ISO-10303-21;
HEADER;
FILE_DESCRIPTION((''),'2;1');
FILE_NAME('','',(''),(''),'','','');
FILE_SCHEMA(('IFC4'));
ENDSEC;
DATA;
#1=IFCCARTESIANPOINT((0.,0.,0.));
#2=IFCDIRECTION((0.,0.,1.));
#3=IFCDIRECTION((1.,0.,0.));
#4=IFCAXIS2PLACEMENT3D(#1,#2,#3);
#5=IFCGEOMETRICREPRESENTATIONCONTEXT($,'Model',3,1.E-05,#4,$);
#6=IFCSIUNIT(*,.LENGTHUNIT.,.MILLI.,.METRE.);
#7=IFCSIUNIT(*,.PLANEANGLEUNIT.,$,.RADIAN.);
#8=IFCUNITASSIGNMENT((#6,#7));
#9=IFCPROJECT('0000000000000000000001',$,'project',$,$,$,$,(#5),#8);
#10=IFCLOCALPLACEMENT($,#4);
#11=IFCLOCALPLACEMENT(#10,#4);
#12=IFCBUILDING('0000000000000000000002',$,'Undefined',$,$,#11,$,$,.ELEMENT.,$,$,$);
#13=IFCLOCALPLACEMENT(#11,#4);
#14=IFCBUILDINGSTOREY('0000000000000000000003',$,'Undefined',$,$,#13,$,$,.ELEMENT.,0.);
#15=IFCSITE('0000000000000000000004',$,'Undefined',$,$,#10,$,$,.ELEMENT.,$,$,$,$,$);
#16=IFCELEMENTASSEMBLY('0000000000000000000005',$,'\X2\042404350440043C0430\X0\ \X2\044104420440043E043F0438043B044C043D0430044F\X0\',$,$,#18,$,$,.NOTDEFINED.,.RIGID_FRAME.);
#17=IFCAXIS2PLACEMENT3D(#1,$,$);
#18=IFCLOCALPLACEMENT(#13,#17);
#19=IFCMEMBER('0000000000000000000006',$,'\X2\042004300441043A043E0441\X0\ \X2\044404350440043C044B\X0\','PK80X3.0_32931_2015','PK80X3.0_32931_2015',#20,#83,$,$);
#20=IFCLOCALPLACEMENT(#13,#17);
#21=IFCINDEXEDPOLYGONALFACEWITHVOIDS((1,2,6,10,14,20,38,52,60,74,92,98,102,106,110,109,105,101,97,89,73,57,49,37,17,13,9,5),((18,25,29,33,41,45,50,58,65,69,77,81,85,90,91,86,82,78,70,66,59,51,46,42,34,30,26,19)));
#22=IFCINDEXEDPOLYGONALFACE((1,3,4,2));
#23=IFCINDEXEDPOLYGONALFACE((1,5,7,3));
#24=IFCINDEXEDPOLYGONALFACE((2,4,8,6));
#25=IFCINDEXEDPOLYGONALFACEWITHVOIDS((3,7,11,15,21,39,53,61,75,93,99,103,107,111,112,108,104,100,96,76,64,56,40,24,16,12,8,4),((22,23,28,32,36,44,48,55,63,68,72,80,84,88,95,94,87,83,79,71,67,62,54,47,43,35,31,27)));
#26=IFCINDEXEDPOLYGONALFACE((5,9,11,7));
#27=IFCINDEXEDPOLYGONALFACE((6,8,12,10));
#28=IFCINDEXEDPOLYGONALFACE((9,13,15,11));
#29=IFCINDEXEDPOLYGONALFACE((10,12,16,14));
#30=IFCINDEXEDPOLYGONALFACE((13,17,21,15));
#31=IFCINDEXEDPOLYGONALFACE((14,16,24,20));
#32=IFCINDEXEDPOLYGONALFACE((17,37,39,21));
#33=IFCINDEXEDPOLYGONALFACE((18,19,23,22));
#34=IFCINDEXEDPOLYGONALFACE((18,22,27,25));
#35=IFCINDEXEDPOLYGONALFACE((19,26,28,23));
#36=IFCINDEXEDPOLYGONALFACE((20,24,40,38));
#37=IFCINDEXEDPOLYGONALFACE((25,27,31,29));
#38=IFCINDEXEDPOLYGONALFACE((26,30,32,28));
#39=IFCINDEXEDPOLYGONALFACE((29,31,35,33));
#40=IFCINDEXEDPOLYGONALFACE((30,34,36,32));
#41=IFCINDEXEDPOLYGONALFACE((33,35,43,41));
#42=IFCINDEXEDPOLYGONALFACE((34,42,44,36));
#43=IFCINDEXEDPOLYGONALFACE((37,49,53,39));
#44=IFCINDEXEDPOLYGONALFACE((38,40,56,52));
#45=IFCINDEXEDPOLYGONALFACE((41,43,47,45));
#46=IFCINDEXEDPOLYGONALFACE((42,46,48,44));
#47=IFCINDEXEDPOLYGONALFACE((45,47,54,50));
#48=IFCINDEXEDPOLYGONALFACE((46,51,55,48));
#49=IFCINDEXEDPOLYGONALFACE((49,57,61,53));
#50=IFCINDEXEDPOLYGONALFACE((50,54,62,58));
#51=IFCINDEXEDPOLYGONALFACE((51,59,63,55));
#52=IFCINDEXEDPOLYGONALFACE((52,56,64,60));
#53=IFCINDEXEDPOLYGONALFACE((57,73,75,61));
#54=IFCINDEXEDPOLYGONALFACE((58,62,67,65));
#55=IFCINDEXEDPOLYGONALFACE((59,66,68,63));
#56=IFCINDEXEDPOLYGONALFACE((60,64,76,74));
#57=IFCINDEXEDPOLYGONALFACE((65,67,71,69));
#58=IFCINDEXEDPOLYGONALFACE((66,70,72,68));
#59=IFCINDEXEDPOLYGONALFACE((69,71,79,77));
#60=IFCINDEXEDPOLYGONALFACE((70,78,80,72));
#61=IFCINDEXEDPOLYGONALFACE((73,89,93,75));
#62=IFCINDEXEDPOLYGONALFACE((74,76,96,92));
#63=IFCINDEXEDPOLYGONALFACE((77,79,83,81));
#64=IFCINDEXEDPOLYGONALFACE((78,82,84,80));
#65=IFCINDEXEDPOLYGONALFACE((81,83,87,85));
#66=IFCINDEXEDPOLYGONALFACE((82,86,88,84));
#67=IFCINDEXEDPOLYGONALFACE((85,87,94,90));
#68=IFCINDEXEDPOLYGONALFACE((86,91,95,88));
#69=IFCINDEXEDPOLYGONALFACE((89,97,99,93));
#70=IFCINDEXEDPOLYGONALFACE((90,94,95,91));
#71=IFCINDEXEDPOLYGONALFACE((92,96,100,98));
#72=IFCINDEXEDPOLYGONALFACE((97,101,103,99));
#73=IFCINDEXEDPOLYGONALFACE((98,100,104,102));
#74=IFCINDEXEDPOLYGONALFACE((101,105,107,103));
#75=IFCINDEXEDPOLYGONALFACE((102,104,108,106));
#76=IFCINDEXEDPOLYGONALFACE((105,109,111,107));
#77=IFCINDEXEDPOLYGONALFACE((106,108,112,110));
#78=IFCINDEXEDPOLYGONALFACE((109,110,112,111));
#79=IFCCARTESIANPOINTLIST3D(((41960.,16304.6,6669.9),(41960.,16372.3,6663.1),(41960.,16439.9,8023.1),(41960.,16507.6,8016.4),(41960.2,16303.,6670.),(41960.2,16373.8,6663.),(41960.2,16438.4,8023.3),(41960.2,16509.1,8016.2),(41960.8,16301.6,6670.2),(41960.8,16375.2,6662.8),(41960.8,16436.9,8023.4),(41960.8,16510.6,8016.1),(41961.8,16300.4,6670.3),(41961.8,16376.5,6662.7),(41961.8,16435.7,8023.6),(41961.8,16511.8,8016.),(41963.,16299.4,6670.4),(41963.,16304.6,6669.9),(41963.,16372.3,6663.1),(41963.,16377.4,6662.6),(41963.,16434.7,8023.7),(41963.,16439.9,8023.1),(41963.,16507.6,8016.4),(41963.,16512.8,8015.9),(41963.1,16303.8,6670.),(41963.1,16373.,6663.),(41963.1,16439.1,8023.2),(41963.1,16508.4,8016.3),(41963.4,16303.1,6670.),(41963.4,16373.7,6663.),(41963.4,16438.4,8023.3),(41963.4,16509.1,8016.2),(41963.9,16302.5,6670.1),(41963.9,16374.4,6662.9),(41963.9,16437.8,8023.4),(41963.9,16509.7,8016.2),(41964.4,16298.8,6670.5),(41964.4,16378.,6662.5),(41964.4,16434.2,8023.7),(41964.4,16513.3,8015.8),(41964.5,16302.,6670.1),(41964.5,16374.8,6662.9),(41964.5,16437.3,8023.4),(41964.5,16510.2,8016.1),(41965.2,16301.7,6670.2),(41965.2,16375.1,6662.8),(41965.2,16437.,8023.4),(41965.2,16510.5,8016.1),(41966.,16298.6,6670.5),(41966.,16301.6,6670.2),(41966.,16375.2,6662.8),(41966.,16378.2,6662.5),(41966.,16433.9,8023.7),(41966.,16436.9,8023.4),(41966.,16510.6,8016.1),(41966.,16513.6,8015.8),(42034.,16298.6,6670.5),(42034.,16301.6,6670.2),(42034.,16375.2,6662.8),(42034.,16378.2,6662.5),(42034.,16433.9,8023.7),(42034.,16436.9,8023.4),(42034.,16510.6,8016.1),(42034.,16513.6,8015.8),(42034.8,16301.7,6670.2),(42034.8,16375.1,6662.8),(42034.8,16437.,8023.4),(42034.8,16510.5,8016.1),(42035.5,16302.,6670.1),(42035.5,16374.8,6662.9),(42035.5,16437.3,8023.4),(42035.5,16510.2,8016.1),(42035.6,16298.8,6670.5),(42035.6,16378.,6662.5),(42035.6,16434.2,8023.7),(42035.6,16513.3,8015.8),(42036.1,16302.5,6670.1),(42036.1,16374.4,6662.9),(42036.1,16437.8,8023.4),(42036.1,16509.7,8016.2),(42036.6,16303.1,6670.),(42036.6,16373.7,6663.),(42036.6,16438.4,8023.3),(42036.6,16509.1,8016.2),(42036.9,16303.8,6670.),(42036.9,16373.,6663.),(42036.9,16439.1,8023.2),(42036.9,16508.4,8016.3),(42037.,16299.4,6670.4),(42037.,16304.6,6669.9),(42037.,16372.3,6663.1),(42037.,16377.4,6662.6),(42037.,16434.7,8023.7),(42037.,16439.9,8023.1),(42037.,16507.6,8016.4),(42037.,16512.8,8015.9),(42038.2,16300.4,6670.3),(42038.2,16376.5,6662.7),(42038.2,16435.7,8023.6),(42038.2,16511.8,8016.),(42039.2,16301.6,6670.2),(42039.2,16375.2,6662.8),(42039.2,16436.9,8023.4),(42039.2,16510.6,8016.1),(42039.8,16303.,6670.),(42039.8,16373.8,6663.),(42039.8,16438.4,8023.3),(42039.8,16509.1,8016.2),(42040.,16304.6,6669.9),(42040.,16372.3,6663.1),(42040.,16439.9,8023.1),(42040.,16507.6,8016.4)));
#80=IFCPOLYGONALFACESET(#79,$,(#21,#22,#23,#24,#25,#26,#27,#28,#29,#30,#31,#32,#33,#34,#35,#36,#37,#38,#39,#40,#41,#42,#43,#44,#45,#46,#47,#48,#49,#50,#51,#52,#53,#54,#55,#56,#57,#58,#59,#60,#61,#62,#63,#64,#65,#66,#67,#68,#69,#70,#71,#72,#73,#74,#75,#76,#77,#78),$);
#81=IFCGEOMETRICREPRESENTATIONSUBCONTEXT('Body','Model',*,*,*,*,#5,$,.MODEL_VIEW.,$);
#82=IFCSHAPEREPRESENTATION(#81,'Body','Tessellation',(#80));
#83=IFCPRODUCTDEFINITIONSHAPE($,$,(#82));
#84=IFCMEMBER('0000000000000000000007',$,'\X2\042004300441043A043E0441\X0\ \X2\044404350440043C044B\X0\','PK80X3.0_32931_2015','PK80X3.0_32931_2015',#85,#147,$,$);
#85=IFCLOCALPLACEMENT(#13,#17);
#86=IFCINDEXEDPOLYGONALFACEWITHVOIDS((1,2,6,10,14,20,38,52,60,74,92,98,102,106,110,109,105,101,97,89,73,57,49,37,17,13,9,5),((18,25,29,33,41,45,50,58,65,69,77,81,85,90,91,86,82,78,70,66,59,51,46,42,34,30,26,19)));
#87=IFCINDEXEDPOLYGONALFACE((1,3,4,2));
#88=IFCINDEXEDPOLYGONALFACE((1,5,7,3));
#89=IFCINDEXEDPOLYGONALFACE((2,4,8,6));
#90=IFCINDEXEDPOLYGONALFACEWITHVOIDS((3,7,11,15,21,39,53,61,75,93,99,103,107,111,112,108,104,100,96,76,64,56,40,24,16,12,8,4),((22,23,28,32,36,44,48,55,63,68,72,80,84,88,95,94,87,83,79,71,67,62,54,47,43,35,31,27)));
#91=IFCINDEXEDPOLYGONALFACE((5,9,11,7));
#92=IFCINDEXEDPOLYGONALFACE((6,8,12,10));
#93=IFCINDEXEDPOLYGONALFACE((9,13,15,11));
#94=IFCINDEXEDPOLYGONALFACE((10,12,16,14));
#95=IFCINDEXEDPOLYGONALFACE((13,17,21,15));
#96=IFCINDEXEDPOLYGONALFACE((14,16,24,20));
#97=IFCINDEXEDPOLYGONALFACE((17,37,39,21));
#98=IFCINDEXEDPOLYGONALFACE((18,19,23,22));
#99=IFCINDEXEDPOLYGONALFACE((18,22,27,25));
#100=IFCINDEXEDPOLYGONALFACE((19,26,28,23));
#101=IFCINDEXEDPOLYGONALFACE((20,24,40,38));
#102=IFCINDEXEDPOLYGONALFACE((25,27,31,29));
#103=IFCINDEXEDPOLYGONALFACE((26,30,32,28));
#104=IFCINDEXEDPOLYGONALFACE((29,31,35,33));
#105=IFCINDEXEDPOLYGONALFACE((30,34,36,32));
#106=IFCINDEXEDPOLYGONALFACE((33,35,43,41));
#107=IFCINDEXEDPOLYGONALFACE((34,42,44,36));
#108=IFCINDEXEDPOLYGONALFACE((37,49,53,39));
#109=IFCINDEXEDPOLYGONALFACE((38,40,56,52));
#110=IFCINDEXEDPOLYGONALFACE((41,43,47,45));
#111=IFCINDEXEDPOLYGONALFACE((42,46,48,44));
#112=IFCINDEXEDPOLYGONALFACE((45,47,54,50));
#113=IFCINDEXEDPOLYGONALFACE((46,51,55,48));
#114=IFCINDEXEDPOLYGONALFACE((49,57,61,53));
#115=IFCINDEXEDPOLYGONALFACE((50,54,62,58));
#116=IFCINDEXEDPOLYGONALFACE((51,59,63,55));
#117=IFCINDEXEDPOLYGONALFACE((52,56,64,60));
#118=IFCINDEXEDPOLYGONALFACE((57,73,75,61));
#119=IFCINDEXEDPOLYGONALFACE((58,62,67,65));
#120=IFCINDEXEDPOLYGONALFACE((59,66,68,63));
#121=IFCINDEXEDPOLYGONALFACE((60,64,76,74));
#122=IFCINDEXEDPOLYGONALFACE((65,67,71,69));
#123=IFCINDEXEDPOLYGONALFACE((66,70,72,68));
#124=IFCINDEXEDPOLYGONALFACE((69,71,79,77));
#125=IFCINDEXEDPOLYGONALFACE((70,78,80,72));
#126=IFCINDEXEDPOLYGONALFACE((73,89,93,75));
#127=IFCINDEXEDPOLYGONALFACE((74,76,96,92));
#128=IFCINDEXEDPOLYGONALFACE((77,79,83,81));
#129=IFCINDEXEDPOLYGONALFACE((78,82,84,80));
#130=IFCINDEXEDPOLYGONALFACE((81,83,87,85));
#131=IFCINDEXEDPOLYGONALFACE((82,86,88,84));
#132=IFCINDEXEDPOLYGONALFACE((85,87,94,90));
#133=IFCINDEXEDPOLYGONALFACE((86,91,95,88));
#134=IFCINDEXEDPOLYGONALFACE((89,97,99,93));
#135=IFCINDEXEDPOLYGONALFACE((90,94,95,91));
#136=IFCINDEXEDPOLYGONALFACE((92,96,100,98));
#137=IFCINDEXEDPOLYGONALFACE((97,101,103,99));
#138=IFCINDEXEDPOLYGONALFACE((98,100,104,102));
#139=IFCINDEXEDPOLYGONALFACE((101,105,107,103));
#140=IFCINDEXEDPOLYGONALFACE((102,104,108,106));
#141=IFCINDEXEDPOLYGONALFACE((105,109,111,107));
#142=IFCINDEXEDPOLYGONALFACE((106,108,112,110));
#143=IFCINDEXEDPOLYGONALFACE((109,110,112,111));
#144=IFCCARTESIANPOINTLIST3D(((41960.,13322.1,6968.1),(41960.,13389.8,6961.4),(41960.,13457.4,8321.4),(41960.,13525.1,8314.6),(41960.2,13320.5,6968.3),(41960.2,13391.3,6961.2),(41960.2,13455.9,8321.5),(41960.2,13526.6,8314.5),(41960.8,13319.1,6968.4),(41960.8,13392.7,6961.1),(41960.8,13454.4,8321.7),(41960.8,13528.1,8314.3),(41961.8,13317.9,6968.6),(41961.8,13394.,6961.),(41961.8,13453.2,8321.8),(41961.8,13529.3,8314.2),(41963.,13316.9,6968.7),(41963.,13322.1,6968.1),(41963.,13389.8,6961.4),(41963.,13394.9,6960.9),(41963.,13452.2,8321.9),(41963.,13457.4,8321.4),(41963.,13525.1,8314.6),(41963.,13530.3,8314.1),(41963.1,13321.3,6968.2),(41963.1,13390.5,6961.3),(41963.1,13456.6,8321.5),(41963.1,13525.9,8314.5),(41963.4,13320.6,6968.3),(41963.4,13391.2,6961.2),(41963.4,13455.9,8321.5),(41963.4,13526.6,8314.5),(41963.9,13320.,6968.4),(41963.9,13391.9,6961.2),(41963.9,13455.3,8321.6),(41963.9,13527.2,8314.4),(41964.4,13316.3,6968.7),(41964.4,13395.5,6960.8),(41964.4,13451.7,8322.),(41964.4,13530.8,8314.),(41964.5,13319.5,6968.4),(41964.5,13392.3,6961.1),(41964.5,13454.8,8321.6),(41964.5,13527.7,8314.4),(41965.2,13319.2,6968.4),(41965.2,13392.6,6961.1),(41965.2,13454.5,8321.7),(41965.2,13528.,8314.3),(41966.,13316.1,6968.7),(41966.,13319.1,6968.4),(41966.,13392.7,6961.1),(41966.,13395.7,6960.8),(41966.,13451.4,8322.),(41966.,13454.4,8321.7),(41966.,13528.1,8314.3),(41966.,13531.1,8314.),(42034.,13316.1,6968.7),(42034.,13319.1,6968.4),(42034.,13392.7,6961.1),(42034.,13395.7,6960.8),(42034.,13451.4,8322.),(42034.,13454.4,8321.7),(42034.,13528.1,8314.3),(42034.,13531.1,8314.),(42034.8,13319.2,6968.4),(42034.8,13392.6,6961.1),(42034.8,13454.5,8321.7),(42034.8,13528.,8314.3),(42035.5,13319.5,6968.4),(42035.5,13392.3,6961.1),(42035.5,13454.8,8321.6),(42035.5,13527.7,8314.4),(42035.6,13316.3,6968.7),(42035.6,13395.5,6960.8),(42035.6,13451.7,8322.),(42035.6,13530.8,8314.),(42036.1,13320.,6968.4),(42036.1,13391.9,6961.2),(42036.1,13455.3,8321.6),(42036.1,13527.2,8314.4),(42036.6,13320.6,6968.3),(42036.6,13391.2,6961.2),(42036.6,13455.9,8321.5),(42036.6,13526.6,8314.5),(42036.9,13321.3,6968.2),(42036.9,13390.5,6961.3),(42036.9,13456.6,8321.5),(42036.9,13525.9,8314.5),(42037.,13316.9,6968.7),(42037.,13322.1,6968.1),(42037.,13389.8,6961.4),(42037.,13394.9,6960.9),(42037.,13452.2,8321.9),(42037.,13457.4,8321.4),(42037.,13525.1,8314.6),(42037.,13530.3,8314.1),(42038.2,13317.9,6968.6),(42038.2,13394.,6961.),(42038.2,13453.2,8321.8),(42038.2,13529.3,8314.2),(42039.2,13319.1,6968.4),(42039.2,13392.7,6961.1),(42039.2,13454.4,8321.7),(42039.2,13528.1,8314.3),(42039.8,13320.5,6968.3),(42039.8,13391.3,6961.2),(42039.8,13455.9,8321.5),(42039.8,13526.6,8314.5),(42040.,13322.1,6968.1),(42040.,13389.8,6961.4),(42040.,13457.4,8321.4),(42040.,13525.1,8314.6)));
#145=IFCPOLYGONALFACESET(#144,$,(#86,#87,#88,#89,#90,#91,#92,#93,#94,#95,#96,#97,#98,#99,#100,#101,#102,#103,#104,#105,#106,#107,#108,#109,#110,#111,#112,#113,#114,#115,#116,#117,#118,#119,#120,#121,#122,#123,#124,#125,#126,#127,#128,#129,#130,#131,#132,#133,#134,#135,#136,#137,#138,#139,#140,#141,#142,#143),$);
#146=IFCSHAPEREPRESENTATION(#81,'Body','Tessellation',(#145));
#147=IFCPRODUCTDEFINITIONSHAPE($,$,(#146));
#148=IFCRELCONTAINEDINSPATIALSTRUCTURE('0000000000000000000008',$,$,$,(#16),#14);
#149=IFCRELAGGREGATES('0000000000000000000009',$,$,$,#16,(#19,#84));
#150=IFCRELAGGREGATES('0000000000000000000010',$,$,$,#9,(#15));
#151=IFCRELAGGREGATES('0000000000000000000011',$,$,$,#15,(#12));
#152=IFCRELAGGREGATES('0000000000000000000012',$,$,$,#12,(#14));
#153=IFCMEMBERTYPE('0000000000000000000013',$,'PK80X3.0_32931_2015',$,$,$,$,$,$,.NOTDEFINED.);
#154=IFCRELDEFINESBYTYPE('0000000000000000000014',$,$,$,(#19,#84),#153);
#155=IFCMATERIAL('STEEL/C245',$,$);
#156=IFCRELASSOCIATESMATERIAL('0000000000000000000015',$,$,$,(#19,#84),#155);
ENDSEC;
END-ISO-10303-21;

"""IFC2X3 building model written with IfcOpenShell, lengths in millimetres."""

from ifc_helpers import new_model, si_unit, frame, origin_with_axes, origin_2d_with_axis, place, context, subcontext, project, spatial, hollow_rectangle, extrude, material, type_object, element, aggregate, save


model = new_model("IFC2X3")

# Units and contexts
model_context = context("Model", 3, precision=1e-05, world=origin_with_axes())
body_context = subcontext(model_context, "Body", "Model", "MODEL_VIEW")
ifc_project = project(units=[si_unit("LENGTHUNIT", "METRE", prefix="MILLI"), si_unit("PLANEANGLEUNIT", "RADIAN")], contexts=[model_context])

# Site, building, storey
site_placement = place(None, origin_with_axes())
site = spatial("IfcSite", under=ifc_project, at=site_placement, Name="Undefined", CompositionType="ELEMENT")
building_placement = place(site_placement, origin_with_axes())
building = spatial("IfcBuilding", under=site, at=building_placement, Name="Undefined", CompositionType="ELEMENT")
storey_placement = place(building_placement, origin_with_axes())
storey = spatial("IfcBuildingStorey", under=building, at=storey_placement, Name="Undefined", CompositionType="ELEMENT", Elevation=0.0)

# Shared definitions
ifc_material_1 = material(Name="STEEL/C245")

# Shared definitions
member_type_1 = type_object("IfcMemberType", Name="PK80X3.0_32931_2015", PredefinedType="NOTDEFINED")

# Element assembly, members
assembly_1_placement = place(storey_placement, origin_with_axes())
assembly_1 = element("IfcElementAssembly", 1, at=assembly_1_placement, inside=storey, Name="Ферма стропильная", AssemblyPlace="NOTDEFINED", PredefinedType="RIGID_FRAME")
member_1_placement = place(assembly_1_placement, frame((42000.0, 16473.7, 8019.8), z_axis=(0.0, -0.995037, 0.099504), x_axis=(0.0, -0.099504, -0.995037)))
member_1 = element("IfcMember", 2, at=member_1_placement, type_object=member_type_1, material=ifc_material_1, Name="Раскос фермы", Description="PK80X3.0_32931_2015", ObjectType="PK80X3.0_32931_2015", context=body_context, shape_type="SweptSolid", body=[
    extrude(hollow_rectangle(XDim=80.0, YDim=80.0, WallThickness=3.0, InnerFilletRadius=3.0, OuterFilletRadius=6.0, at=origin_2d_with_axis()), frame((1360.0, 0.0, 0.0), z_axis=(-1.0, 0.0, 0.0), x_axis=(0.0, -1.0, 0.0)), (0.0, 0.0, 1.0), 1360.0),
])
member_2_placement = place(assembly_1_placement, frame((42000.0, 13491.2, 8318.0), z_axis=(0.0, -0.995037, 0.099504), x_axis=(0.0, -0.099504, -0.995037)))
member_2 = element("IfcMember", 3, at=member_2_placement, type_object=member_type_1, material=ifc_material_1, Name="Раскос фермы", Description="PK80X3.0_32931_2015", ObjectType="PK80X3.0_32931_2015", context=body_context, shape_type="SweptSolid", body=[
    extrude(hollow_rectangle(XDim=80.0, YDim=80.0, WallThickness=3.0, InnerFilletRadius=3.0, OuterFilletRadius=6.0, at=origin_2d_with_axis()), frame((1360.0, 0.0, 0.0), z_axis=(-1.0, 0.0, 0.0), x_axis=(0.0, -1.0, 0.0)), (0.0, 0.0, 1.0), 1360.0),
])

aggregate(assembly_1, [member_1, member_2])

save(model, "model.ifc")
